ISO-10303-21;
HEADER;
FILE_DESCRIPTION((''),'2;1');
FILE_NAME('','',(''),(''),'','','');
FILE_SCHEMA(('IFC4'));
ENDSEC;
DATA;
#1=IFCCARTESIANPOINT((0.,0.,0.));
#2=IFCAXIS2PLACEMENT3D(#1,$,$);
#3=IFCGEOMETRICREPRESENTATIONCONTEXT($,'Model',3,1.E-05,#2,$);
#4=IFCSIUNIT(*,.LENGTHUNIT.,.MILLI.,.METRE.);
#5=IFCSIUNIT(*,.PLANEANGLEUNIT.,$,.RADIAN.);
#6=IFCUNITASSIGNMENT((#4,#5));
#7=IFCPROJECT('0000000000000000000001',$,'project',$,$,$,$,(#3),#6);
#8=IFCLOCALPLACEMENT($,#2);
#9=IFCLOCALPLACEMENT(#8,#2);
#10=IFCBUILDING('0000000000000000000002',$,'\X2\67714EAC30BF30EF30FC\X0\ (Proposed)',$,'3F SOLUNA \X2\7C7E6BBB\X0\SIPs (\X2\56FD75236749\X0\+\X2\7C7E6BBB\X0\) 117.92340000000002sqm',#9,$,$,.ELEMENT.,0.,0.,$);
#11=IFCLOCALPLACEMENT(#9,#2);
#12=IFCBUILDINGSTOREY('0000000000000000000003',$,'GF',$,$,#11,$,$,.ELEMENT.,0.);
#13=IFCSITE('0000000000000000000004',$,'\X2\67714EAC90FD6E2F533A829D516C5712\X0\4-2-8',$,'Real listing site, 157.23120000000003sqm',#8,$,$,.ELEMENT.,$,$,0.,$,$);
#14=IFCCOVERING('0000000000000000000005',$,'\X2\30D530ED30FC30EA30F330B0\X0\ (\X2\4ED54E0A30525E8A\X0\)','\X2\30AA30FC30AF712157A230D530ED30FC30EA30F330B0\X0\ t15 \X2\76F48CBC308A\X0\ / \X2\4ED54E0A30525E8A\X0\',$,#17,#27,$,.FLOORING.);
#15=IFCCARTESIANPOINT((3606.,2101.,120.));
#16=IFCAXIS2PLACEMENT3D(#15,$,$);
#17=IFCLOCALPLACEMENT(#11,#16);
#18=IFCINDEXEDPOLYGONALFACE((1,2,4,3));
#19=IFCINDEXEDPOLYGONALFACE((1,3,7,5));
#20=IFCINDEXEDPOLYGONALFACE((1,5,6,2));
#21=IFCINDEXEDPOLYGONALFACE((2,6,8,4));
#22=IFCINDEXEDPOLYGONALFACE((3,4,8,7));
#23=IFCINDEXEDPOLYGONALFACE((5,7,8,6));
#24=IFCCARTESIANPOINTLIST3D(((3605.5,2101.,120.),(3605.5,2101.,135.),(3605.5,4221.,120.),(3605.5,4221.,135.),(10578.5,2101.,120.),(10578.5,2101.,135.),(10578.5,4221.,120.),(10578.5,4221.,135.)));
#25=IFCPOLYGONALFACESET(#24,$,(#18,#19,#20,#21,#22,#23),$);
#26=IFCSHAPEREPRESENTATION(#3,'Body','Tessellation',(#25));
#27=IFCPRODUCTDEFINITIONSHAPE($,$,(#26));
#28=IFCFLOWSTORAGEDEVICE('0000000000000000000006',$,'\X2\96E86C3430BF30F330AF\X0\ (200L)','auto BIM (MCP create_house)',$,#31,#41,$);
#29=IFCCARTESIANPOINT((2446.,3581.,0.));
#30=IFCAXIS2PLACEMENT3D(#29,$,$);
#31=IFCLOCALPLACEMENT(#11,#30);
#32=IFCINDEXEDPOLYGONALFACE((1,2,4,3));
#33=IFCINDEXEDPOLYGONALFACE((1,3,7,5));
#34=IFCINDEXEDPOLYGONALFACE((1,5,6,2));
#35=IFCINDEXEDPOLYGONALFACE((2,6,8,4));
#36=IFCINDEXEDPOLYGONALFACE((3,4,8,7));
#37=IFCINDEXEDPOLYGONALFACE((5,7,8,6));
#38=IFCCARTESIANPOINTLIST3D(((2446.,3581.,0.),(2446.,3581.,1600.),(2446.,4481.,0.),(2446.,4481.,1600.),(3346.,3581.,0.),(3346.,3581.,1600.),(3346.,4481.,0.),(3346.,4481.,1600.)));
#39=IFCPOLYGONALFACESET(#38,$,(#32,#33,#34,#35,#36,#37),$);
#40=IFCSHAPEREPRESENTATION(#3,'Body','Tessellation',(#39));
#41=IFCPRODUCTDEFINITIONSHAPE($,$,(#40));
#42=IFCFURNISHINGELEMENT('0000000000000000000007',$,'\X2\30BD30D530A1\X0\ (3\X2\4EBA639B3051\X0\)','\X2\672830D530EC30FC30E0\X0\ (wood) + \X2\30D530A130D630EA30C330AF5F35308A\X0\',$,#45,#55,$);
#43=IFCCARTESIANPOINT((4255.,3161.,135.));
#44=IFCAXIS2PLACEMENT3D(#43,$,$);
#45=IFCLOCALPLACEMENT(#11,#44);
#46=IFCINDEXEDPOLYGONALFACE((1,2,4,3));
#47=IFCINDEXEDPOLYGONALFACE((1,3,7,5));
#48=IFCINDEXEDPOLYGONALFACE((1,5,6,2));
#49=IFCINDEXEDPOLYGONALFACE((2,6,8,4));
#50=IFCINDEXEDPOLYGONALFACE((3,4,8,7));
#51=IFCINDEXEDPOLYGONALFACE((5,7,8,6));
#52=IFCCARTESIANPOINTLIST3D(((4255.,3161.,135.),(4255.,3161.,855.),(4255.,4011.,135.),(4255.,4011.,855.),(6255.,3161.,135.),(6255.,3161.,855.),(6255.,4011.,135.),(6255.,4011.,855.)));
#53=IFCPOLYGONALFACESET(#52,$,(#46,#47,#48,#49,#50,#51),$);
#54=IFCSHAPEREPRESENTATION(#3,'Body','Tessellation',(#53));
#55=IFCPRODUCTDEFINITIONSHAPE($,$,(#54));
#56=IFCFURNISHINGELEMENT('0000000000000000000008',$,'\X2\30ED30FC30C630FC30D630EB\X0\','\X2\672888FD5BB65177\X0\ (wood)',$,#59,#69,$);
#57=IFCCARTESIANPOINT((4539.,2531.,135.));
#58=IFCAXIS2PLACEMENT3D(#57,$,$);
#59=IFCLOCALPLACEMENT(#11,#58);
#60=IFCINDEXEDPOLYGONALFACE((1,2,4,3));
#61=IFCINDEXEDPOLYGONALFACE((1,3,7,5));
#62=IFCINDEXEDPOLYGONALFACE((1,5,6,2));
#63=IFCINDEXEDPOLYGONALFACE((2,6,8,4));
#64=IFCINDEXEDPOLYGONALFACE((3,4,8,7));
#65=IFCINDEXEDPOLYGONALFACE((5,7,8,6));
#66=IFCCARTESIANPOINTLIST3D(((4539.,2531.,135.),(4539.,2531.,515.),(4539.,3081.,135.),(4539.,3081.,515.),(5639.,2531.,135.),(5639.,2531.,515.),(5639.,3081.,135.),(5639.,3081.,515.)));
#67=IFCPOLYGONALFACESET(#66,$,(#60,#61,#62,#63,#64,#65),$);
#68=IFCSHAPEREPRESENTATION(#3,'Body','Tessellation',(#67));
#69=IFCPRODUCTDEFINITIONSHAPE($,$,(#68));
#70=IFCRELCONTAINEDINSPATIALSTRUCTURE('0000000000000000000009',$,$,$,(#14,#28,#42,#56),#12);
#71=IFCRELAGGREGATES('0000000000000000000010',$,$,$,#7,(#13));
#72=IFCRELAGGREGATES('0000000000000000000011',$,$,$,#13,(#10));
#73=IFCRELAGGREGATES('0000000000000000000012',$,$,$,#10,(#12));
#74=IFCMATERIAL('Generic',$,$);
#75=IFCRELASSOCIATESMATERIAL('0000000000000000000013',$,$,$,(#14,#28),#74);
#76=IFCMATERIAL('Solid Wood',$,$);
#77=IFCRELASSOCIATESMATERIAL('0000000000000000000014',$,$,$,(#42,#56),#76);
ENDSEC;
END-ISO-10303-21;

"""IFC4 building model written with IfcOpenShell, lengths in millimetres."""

from ifc_helpers import new_model, si_unit, frame, frame_2d, origin, place, context, project, spatial, rectangle, extrude, material, element, save


model = new_model("IFC4")

# Units and contexts
model_context = context("Model", 3, precision=1e-05, world=origin())
ifc_project = project(units=[si_unit("LENGTHUNIT", "METRE", prefix="MILLI"), si_unit("PLANEANGLEUNIT", "RADIAN")], contexts=[model_context])

# Site, building, storey
site_placement = place(None, origin())
site = spatial("IfcSite", under=ifc_project, at=site_placement, Name="東京都港区芝公園4-2-8", ObjectType="Real listing site, 157.23120000000003sqm", CompositionType="ELEMENT", RefElevation=0.0)
building_placement = place(site_placement, origin())
building = spatial("IfcBuilding", under=site, at=building_placement, Name="東京タワー (Proposed)", ObjectType="3F SOLUNA 籾殻SIPs (国産杉+籾殻) 117.92340000000002sqm", CompositionType="ELEMENT", ElevationOfRefHeight=0.0, ElevationOfTerrain=0.0)
storey_placement = place(building_placement, origin())
storey = spatial("IfcBuildingStorey", under=building, at=storey_placement, Name="GF", CompositionType="ELEMENT", Elevation=0.0)

# Shared definitions
ifc_material_1 = material(Name="Solid Wood")

# Covering
ifc_material_2 = material(Name="Generic")
covering_placement = place(storey_placement, frame((3606.0, 2101.0, 120.0)))
element("IfcCovering", 1, at=covering_placement, inside=storey, material=ifc_material_2, Name="フローリング (仕上げ床)", Description="オーク無垢フローリング t15 直貼り / 仕上げ床", PredefinedType="FLOORING", context=model_context, shape_type="SweptSolid", body=[
    extrude(rectangle(XDim=6973.0, YDim=2120.0, at=frame_2d((3486.0, 1060.0))), frame((3606.0, 2101.0, 120.0)), (0.0, 0.0, 1.0), 15.0),
])

# Flow storage device
flow_storage_device_placement = place(storey_placement, frame((2446.0, 3581.0, 0.0)))
element("IfcFlowStorageDevice", 2, at=flow_storage_device_placement, inside=storey, material=ifc_material_2, Name="雨水タンク (200L)", Description="auto BIM (MCP create_house)", context=model_context, shape_type="SweptSolid", body=[
    extrude(rectangle(XDim=900.0, YDim=900.0, at=frame_2d((450.0, 450.0))), frame((2446.0, 3581.0, 0.0)), (0.0, 0.0, 1.0), 1600.0),
])

# Furnishing elements
furnishing_1_placement = place(storey_placement, frame((4255.0, 3161.0, 135.0)))
element("IfcFurnishingElement", 3, at=furnishing_1_placement, inside=storey, material=ifc_material_1, Name="ソファ (3人掛け)", Description="木フレーム (wood) + ファブリック張り", context=model_context, shape_type="SweptSolid", body=[
    extrude(rectangle(XDim=2000.0, YDim=850.0, at=frame_2d((1000.0, 425.0))), frame((4255.0, 3161.0, 135.0)), (0.0, 0.0, 1.0), 720.0),
])
furnishing_2_placement = place(storey_placement, frame((4539.0, 2531.0, 135.0)))
element("IfcFurnishingElement", 4, at=furnishing_2_placement, inside=storey, material=ifc_material_1, Name="ローテーブル", Description="木製家具 (wood)", context=model_context, shape_type="SweptSolid", body=[
    extrude(rectangle(XDim=1100.0, YDim=550.0, at=frame_2d((550.0, 275.0))), frame((4539.0, 2531.0, 135.0)), (0.0, 0.0, 1.0), 380.0),
])

save(model, "model.ifc")
